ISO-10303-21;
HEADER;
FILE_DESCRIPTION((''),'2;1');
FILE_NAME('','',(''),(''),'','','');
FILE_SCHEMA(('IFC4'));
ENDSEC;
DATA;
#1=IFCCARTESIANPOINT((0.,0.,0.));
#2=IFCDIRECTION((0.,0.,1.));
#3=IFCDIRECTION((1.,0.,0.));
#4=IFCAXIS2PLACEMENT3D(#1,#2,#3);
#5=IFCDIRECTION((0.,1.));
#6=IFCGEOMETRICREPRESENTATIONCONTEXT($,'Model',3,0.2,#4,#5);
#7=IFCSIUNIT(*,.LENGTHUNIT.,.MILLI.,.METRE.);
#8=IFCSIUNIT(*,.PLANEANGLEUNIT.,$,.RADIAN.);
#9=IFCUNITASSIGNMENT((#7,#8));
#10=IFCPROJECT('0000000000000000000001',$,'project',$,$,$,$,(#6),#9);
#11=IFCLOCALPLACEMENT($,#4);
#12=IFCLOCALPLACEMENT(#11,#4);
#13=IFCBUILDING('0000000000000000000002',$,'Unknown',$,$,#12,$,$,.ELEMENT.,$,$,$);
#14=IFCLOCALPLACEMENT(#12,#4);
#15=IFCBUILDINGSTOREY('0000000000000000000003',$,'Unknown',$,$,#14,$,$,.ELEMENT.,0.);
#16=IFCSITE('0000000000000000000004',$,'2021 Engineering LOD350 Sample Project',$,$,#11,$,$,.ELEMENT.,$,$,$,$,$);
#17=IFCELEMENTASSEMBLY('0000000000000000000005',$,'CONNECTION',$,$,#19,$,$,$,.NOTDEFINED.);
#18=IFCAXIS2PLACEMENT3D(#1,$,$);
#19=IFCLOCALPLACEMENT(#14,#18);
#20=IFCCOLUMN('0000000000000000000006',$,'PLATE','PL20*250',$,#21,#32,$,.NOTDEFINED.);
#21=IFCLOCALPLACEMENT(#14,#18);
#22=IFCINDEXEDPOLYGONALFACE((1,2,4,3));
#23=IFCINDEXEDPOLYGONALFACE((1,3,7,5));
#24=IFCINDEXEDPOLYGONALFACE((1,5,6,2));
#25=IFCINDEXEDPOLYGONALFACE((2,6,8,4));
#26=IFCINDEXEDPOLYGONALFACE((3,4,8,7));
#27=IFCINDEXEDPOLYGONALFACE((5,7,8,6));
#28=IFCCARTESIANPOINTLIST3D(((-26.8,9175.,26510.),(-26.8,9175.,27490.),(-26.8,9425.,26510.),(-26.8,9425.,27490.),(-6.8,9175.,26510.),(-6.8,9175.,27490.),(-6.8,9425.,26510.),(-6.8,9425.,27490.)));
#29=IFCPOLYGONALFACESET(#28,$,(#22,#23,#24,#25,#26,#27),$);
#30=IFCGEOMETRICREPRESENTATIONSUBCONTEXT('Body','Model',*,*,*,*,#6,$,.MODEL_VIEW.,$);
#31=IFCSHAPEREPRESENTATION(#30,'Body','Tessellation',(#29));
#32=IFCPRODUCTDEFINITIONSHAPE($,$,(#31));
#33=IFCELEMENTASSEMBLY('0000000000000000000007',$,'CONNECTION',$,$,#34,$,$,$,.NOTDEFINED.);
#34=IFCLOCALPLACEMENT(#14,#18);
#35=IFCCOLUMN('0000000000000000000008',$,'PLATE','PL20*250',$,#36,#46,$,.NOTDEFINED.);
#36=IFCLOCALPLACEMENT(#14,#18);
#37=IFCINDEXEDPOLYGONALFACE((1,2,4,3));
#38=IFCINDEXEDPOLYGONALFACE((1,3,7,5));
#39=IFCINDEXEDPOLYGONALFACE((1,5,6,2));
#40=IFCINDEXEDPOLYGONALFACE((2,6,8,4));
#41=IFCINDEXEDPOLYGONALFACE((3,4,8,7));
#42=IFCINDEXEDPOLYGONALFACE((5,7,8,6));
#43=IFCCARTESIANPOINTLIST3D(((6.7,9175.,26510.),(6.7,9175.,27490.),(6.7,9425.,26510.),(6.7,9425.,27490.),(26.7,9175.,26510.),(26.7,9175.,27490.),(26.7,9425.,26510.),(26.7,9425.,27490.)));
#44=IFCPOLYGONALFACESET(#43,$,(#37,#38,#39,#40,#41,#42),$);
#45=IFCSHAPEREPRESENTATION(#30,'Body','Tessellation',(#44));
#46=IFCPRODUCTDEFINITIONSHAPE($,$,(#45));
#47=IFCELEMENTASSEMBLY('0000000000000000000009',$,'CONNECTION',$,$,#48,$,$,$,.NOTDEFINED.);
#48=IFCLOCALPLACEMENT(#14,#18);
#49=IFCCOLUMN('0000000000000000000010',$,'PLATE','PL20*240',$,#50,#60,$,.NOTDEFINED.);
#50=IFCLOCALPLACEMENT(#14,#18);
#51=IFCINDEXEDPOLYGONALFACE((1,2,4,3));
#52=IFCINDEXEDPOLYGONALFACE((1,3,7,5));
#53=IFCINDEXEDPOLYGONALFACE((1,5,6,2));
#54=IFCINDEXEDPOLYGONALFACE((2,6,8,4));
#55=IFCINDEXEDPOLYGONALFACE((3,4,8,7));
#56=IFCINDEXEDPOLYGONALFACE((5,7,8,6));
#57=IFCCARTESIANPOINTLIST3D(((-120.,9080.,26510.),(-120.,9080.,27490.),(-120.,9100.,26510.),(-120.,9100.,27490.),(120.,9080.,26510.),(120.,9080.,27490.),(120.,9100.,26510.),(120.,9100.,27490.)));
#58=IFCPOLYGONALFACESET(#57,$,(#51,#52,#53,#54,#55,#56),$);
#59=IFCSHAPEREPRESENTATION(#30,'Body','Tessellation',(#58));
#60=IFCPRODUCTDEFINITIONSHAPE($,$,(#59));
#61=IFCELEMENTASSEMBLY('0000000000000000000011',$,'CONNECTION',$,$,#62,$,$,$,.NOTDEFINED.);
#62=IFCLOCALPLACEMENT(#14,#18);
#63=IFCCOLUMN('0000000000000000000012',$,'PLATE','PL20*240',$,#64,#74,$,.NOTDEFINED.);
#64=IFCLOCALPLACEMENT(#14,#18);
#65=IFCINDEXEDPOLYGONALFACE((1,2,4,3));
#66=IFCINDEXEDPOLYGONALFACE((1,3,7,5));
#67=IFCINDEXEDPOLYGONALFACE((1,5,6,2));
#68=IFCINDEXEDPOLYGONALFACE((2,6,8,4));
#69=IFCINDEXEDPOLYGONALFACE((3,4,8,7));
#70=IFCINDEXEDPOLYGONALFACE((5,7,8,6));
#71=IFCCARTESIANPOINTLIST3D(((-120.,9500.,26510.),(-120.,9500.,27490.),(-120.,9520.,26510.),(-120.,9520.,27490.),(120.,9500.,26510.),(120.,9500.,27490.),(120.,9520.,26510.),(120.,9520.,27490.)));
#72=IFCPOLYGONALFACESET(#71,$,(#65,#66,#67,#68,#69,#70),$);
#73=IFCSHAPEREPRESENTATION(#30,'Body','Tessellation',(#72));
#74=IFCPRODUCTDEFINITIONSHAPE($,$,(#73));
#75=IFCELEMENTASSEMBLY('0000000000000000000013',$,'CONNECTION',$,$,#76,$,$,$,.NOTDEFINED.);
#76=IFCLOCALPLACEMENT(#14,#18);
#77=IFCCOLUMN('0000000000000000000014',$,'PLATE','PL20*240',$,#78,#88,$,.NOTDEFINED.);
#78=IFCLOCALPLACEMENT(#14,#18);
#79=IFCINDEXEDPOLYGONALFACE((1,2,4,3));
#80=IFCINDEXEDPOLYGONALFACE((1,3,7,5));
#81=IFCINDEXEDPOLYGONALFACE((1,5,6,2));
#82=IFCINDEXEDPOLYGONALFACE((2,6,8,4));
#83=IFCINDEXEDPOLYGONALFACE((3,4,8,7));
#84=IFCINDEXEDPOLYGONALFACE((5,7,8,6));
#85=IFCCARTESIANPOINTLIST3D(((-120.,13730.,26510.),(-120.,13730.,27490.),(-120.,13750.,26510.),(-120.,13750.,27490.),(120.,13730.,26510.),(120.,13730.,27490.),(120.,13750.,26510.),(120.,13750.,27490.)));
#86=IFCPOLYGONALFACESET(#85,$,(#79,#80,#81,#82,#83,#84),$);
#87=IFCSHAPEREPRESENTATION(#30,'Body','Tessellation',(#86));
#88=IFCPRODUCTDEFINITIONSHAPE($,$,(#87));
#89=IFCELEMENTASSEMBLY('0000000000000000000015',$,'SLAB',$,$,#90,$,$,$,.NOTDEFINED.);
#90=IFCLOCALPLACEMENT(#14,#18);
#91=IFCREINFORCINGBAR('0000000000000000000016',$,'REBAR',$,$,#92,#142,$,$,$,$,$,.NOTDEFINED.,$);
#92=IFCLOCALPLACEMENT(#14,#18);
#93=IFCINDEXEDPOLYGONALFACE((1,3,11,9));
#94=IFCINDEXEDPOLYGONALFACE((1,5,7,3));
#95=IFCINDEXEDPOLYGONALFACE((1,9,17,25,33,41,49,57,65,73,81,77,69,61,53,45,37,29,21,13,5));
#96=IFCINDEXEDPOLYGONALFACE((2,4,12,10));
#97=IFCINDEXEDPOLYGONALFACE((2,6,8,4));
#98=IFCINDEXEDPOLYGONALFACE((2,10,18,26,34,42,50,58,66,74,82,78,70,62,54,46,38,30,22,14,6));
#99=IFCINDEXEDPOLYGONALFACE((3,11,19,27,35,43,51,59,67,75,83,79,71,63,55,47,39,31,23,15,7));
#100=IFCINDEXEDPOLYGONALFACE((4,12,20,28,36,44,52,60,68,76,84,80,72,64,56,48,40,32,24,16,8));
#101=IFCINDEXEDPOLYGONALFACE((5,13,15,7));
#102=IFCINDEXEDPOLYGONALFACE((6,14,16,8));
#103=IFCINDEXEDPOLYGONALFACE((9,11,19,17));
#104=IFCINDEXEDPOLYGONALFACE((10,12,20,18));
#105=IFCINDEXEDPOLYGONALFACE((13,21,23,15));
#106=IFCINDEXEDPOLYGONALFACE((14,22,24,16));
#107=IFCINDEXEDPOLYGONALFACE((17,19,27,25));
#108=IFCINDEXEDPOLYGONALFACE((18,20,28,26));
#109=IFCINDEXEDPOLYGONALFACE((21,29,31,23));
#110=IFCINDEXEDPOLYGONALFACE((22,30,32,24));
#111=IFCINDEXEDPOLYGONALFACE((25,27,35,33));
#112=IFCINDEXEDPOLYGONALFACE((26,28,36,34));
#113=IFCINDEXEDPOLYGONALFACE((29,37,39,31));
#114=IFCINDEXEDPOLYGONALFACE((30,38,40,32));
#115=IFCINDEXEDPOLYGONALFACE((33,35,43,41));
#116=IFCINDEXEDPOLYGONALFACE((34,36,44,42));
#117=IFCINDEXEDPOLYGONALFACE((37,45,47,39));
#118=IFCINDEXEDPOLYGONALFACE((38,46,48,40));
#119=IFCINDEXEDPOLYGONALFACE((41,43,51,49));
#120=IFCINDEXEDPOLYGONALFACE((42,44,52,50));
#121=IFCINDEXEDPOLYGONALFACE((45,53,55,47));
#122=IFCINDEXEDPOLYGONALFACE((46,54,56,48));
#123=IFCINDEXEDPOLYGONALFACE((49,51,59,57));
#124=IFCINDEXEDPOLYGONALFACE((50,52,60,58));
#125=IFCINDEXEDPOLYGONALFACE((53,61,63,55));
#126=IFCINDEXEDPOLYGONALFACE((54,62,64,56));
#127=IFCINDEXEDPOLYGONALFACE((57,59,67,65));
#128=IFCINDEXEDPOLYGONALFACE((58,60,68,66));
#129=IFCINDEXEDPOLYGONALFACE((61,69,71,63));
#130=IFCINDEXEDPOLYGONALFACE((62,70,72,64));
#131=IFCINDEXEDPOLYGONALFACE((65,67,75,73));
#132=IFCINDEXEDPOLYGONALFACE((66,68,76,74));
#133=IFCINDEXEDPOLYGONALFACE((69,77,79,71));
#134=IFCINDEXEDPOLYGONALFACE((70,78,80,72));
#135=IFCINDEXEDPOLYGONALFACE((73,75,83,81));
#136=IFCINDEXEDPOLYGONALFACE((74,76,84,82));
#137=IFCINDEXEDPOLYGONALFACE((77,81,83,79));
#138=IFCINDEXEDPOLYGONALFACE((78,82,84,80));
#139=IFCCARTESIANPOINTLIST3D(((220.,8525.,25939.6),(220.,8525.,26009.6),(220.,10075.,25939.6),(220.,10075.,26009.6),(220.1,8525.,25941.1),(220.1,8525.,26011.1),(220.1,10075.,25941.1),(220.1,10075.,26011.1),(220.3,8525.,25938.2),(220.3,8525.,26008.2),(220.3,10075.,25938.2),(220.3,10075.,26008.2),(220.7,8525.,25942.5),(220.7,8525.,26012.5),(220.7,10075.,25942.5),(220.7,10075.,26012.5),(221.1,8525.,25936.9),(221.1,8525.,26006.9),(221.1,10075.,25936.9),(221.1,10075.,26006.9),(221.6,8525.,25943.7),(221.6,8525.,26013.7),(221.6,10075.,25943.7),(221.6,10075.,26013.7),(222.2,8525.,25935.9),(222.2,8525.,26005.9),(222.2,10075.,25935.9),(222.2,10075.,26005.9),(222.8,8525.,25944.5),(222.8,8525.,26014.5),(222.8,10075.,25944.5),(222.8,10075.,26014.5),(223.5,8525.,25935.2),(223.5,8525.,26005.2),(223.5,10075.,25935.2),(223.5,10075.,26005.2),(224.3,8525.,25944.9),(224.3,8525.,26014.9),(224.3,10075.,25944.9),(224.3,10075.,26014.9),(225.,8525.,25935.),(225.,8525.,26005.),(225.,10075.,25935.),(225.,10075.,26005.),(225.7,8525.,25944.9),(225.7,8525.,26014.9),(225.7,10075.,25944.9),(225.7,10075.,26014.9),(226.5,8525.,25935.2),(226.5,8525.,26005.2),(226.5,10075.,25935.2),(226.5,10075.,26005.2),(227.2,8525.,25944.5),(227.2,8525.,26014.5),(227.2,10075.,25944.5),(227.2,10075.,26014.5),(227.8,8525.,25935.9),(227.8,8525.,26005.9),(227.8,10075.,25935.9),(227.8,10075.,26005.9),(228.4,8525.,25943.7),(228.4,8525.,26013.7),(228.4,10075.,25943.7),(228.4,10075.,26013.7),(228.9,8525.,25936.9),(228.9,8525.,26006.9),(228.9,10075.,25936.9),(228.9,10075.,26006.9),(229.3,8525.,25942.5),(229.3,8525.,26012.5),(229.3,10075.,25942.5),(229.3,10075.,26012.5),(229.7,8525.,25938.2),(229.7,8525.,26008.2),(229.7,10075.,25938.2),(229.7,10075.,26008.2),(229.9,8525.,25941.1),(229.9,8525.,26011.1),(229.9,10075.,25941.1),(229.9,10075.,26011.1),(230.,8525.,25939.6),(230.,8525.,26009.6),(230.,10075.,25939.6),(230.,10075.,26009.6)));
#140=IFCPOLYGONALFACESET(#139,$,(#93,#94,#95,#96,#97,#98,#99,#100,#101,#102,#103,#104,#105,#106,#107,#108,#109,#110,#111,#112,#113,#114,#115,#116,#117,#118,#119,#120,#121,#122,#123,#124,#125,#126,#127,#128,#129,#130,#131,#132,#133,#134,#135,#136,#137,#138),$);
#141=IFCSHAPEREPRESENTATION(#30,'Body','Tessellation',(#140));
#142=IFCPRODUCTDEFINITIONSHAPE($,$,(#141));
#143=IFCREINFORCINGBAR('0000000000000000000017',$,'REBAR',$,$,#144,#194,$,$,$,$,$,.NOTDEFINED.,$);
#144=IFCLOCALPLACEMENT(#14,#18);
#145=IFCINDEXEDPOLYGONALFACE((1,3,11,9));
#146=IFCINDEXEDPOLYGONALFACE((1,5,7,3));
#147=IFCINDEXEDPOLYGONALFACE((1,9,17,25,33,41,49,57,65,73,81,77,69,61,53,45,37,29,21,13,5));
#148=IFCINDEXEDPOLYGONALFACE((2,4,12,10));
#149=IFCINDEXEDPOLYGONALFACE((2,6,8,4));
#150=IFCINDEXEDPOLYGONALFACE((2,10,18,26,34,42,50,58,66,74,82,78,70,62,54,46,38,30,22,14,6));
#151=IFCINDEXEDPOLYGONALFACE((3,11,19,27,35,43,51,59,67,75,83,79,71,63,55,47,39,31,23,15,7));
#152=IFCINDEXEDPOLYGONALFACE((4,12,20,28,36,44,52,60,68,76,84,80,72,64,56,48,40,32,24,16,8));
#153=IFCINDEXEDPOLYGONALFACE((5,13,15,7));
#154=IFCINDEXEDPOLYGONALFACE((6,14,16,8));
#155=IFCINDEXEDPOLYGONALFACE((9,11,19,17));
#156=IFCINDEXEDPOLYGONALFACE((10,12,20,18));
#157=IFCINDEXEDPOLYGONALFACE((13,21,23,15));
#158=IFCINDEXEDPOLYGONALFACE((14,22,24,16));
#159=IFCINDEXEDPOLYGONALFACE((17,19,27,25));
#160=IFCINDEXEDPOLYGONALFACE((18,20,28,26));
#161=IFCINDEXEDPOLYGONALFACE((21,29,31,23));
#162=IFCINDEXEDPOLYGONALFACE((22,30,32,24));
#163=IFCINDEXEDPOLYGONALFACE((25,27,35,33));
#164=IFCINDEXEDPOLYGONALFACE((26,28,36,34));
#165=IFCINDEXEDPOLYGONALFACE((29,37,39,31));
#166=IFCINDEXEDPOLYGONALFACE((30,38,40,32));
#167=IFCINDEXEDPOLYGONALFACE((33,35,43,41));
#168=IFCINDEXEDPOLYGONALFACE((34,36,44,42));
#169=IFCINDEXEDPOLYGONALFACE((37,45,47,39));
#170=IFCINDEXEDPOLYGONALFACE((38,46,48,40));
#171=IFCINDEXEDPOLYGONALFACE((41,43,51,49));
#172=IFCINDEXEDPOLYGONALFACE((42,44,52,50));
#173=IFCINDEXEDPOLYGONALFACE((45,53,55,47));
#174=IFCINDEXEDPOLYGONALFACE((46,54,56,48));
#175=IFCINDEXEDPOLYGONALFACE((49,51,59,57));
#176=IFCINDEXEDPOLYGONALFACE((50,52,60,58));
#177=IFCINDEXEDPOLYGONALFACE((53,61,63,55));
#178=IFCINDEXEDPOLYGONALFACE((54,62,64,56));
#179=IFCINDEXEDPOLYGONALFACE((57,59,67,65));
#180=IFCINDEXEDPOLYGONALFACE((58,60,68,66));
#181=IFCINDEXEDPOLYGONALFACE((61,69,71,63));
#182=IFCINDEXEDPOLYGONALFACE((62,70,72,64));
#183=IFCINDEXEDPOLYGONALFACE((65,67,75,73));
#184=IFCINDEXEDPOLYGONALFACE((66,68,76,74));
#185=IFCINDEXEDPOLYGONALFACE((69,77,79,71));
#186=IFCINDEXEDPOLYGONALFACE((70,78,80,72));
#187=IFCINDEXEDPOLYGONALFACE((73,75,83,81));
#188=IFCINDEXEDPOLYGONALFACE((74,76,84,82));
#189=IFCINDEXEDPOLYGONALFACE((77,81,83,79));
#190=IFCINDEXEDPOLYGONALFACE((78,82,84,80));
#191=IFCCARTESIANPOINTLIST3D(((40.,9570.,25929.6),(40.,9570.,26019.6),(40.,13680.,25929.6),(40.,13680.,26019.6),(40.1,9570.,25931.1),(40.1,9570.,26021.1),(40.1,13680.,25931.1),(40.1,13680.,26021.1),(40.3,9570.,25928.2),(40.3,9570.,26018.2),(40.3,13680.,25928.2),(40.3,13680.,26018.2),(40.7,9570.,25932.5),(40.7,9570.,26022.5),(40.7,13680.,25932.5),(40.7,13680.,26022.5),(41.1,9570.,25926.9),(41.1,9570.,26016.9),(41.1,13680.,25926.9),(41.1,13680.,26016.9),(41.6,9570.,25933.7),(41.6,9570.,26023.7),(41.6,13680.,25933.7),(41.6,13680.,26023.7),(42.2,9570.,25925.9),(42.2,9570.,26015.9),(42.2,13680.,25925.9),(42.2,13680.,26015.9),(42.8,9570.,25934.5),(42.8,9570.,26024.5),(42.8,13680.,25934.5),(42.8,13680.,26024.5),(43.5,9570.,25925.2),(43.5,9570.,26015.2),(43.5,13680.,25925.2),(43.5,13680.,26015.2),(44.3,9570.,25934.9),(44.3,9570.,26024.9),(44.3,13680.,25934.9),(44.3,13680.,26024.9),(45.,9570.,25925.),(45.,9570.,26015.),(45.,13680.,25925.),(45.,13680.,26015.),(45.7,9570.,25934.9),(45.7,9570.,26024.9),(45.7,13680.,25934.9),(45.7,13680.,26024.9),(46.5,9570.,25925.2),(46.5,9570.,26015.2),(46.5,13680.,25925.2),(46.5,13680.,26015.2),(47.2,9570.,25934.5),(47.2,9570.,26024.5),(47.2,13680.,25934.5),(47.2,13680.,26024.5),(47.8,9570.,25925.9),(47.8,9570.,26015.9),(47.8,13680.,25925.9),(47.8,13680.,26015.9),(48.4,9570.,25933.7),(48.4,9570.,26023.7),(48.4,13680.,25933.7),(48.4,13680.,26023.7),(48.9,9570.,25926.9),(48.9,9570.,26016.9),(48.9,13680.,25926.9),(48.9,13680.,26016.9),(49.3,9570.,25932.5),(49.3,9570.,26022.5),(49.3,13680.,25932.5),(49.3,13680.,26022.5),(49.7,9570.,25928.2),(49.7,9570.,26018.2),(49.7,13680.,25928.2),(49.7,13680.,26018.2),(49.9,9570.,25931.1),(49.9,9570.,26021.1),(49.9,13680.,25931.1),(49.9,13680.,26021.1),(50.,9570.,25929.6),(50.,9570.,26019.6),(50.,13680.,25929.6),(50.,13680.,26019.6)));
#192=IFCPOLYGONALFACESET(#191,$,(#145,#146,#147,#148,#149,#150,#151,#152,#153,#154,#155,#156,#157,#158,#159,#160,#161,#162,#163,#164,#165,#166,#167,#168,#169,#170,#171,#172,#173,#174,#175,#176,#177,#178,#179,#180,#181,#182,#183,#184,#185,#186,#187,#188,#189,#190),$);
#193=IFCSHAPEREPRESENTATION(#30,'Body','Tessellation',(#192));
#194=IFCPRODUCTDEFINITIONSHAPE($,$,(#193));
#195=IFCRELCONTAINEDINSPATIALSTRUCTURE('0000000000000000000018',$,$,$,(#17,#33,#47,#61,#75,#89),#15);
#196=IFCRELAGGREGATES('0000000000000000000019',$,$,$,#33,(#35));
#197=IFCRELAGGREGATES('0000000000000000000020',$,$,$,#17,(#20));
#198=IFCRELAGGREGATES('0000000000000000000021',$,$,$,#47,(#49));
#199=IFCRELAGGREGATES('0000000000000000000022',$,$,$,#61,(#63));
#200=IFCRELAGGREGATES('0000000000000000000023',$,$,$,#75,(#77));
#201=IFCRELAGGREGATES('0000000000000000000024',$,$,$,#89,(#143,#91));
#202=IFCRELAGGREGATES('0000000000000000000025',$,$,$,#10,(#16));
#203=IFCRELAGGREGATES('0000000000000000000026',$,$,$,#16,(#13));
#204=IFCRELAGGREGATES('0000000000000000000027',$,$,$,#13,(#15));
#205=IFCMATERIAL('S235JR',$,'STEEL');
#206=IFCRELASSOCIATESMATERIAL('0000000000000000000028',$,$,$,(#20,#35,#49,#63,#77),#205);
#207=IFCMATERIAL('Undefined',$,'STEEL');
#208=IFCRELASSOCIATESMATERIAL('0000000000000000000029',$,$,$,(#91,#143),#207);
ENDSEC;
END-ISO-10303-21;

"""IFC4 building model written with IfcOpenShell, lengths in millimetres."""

from ifc_helpers import new_model, entity, si_unit, direction, frame, origin_with_axes, place, context, subcontext, project, spatial, line, indexed_curve, outline, extrude, source, transform, mapped, material, element, aggregate, save


model = new_model("IFC4")

# Units and contexts
model_context = context("Model", 3, precision=0.2, world=origin_with_axes(), true_north=direction((0.0, 1.0)))
body_context = subcontext(model_context, "Body", "Model", "MODEL_VIEW")
ifc_project = project(units=[si_unit("LENGTHUNIT", "METRE", prefix="MILLI"), si_unit("PLANEANGLEUNIT", "RADIAN")], contexts=[model_context])

# Site, building, storey
site_placement = place(None, origin_with_axes())
site = spatial("IfcSite", under=ifc_project, at=site_placement, Name="2021 Engineering LOD350 Sample Project", CompositionType="ELEMENT")
building_placement = place(site_placement, origin_with_axes())
building = spatial("IfcBuilding", under=site, at=building_placement, Name="Unknown", CompositionType="ELEMENT")
storey_placement = place(building_placement, origin_with_axes())
storey = spatial("IfcBuildingStorey", under=building, at=storey_placement, Name="Unknown", CompositionType="ELEMENT", Elevation=0.0)

# Element assemblies, columns
assembly_1_placement = place(storey_placement, frame((-16.8, 9300.0, 26510.0), z_axis=(-1.0, 0.0, 0.0), x_axis=(0.0, 0.0, 1.0)))
assembly_1 = element("IfcElementAssembly", 1, at=assembly_1_placement, inside=storey, Name="CONNECTION", PredefinedType="NOTDEFINED")
ifc_material_1 = material(Name="S235JR", Category="STEEL")
column_1_placement = place(assembly_1_placement, origin_with_axes())
column_1 = element("IfcColumn", 2, at=column_1_placement, material=ifc_material_1, Name="PLATE", Description="PL20*250", PredefinedType="NOTDEFINED", context=body_context, shape_type="SolidModel", body=[
    extrude(outline(indexed_curve([(-10.0, -125.0), (10.0, -125.0), (10.0, 125.0), (-10.0, 125.0)], segments=[line(1, 2, 3, 4, 1)])), frame((0.0, 0.0, 0.0), z_axis=(-1.0, 0.0, 0.0), x_axis=(0.0, 0.0, 1.0)), (0.0, 0.0, -1.0), 980.0),
])
assembly_2_placement = place(storey_placement, frame((16.7, 9300.0, 26510.0), z_axis=(-1.0, 0.0, 0.0), x_axis=(0.0, 0.0, 1.0)))
assembly_2 = element("IfcElementAssembly", 3, at=assembly_2_placement, inside=storey, Name="CONNECTION", PredefinedType="NOTDEFINED")
column_2_placement = place(assembly_2_placement, origin_with_axes())
column_2 = element("IfcColumn", 4, at=column_2_placement, material=ifc_material_1, Name="PLATE", Description="PL20*250", PredefinedType="NOTDEFINED", context=body_context, shape_type="SolidModel", body=[
    extrude(outline(indexed_curve([(-10.0, -125.0), (10.0, -125.0), (10.0, 125.0), (-10.0, 125.0)], segments=[line(1, 2, 3, 4, 1)])), frame((0.0, 0.0, 0.0), z_axis=(-1.0, 0.0, 0.0), x_axis=(0.0, 0.0, 1.0)), (0.0, 0.0, -1.0), 980.0),
])
aggregate(assembly_2, [column_2])
assembly_3_placement = place(storey_placement, frame((0.0, 9090.0, 26510.0), z_axis=(0.0, -1.0, 0.0), x_axis=(0.0, 0.0, 1.0)))
assembly_3 = element("IfcElementAssembly", 5, at=assembly_3_placement, inside=storey, Name="CONNECTION", PredefinedType="NOTDEFINED")
column_3_placement = place(assembly_3_placement, origin_with_axes())
column_3 = element("IfcColumn", 6, at=column_3_placement, material=ifc_material_1, Name="PLATE", Description="PL20*240", PredefinedType="NOTDEFINED", context=body_context, shape_type="SolidModel", body=[
    extrude(outline(indexed_curve([(-10.0, -120.0), (10.0, -120.0), (10.0, 120.0), (-10.0, 120.0)], segments=[line(1, 2, 3, 4, 1)])), frame((0.0, 0.0, 0.0), z_axis=(-1.0, 0.0, 0.0), x_axis=(0.0, 0.0, 1.0)), (0.0, 0.0, -1.0), 980.0),
])
assembly_4_placement = place(storey_placement, frame((0.0, 9510.0, 26510.0), z_axis=(0.0, 1.0, 0.0), x_axis=(0.0, 0.0, 1.0)))
assembly_4 = element("IfcElementAssembly", 7, at=assembly_4_placement, inside=storey, Name="CONNECTION", PredefinedType="NOTDEFINED")
column_4_placement = place(assembly_4_placement, origin_with_axes())
column_4 = element("IfcColumn", 8, at=column_4_placement, material=ifc_material_1, Name="PLATE", Description="PL20*240", PredefinedType="NOTDEFINED", context=body_context, shape_type="SolidModel", body=[
    extrude(outline(indexed_curve([(-10.0, -120.0), (10.0, -120.0), (10.0, 120.0), (-10.0, 120.0)], segments=[line(1, 2, 3, 4, 1)])), frame((0.0, 0.0, 0.0), z_axis=(-1.0, 0.0, 0.0), x_axis=(0.0, 0.0, 1.0)), (0.0, 0.0, -1.0), 980.0),
])
assembly_5_placement = place(storey_placement, frame((0.0, 13740.0, 26510.0), z_axis=(0.0, -1.0, 0.0), x_axis=(0.0, 0.0, 1.0)))
assembly_5 = element("IfcElementAssembly", 9, at=assembly_5_placement, inside=storey, Name="CONNECTION", PredefinedType="NOTDEFINED")
column_5_placement = place(assembly_5_placement, origin_with_axes())
column_5 = element("IfcColumn", 10, at=column_5_placement, material=ifc_material_1, Name="PLATE", Description="PL20*240", PredefinedType="NOTDEFINED", context=body_context, shape_type="SolidModel", body=[
    extrude(outline(indexed_curve([(-10.0, -120.0), (10.0, -120.0), (10.0, 120.0), (-10.0, 120.0)], segments=[line(1, 2, 3, 4, 1)])), frame((0.0, 0.0, 0.0), z_axis=(-1.0, 0.0, 0.0), x_axis=(0.0, 0.0, 1.0)), (0.0, 0.0, -1.0), 980.0),
])

# Element assembly, reinforcing bars
assembly_6_placement = place(storey_placement, frame((0.0, 19194.4, 25975.0), z_axis=(0.0, 0.0, 1.0), x_axis=(0.0, -1.0, 0.0)))
assembly_6 = element("IfcElementAssembly", 11, at=assembly_6_placement, inside=storey, Name="SLAB", PredefinedType="NOTDEFINED")
ifc_material_2 = material(Name="Undefined", Category="STEEL")
shared_shape_1 = source(origin_with_axes(), body_context, "Body", "AdvancedSweptSolid", [
    entity("IfcSweptDiskSolid", entity("IfcIndexedPolyCurve", entity("IfcCartesianPointList3D", [[0.0, 0.0, 0.0], [1550.0, 0.0, 0.0]]), [entity("IfcLineIndex", [1, 2])]), 5.0),
])
reinforcing_bar_1_placement = place(assembly_6_placement, frame((9119.4, 225.0, -35.0), z_axis=(0.0, 0.0, -1.0), x_axis=(1.0, 0.0, 0.0)))
reinforcing_bar_1 = element("IfcReinforcingBar", 12, at=reinforcing_bar_1_placement, material=ifc_material_2, Name="REBAR", PredefinedType="NOTDEFINED", context=body_context, shape_type="MappedRepresentation", body=[
    mapped(shared_shape_1, transform((0.0, 0.0, 0.0))),
    mapped(shared_shape_1, transform((0.0, 0.0, -70.0))),
])
shared_shape_2 = source(origin_with_axes(), body_context, "Body", "AdvancedSweptSolid", [
    entity("IfcSweptDiskSolid", entity("IfcIndexedPolyCurve", entity("IfcCartesianPointList3D", [[0.0, 0.0, 0.0], [4110.0, 0.0, 0.0]]), [entity("IfcLineIndex", [1, 2])]), 5.0),
])
reinforcing_bar_2_placement = place(assembly_6_placement, frame((5514.4, 45.0, -45.0), z_axis=(0.0, 0.0, -1.0), x_axis=(1.0, 0.0, 0.0)))
reinforcing_bar_2 = element("IfcReinforcingBar", 13, at=reinforcing_bar_2_placement, material=ifc_material_2, Name="REBAR", PredefinedType="NOTDEFINED", context=body_context, shape_type="MappedRepresentation", body=[
    mapped(shared_shape_2, transform((0.0, 0.0, 0.0))),
    mapped(shared_shape_2, transform((0.0, 0.0, -90.0))),
])

aggregate(assembly_1, [column_1])

aggregate(assembly_3, [column_3])
aggregate(assembly_4, [column_4])
aggregate(assembly_5, [column_5])

aggregate(assembly_6, [reinforcing_bar_2, reinforcing_bar_1])

save(model, "model.ifc")
